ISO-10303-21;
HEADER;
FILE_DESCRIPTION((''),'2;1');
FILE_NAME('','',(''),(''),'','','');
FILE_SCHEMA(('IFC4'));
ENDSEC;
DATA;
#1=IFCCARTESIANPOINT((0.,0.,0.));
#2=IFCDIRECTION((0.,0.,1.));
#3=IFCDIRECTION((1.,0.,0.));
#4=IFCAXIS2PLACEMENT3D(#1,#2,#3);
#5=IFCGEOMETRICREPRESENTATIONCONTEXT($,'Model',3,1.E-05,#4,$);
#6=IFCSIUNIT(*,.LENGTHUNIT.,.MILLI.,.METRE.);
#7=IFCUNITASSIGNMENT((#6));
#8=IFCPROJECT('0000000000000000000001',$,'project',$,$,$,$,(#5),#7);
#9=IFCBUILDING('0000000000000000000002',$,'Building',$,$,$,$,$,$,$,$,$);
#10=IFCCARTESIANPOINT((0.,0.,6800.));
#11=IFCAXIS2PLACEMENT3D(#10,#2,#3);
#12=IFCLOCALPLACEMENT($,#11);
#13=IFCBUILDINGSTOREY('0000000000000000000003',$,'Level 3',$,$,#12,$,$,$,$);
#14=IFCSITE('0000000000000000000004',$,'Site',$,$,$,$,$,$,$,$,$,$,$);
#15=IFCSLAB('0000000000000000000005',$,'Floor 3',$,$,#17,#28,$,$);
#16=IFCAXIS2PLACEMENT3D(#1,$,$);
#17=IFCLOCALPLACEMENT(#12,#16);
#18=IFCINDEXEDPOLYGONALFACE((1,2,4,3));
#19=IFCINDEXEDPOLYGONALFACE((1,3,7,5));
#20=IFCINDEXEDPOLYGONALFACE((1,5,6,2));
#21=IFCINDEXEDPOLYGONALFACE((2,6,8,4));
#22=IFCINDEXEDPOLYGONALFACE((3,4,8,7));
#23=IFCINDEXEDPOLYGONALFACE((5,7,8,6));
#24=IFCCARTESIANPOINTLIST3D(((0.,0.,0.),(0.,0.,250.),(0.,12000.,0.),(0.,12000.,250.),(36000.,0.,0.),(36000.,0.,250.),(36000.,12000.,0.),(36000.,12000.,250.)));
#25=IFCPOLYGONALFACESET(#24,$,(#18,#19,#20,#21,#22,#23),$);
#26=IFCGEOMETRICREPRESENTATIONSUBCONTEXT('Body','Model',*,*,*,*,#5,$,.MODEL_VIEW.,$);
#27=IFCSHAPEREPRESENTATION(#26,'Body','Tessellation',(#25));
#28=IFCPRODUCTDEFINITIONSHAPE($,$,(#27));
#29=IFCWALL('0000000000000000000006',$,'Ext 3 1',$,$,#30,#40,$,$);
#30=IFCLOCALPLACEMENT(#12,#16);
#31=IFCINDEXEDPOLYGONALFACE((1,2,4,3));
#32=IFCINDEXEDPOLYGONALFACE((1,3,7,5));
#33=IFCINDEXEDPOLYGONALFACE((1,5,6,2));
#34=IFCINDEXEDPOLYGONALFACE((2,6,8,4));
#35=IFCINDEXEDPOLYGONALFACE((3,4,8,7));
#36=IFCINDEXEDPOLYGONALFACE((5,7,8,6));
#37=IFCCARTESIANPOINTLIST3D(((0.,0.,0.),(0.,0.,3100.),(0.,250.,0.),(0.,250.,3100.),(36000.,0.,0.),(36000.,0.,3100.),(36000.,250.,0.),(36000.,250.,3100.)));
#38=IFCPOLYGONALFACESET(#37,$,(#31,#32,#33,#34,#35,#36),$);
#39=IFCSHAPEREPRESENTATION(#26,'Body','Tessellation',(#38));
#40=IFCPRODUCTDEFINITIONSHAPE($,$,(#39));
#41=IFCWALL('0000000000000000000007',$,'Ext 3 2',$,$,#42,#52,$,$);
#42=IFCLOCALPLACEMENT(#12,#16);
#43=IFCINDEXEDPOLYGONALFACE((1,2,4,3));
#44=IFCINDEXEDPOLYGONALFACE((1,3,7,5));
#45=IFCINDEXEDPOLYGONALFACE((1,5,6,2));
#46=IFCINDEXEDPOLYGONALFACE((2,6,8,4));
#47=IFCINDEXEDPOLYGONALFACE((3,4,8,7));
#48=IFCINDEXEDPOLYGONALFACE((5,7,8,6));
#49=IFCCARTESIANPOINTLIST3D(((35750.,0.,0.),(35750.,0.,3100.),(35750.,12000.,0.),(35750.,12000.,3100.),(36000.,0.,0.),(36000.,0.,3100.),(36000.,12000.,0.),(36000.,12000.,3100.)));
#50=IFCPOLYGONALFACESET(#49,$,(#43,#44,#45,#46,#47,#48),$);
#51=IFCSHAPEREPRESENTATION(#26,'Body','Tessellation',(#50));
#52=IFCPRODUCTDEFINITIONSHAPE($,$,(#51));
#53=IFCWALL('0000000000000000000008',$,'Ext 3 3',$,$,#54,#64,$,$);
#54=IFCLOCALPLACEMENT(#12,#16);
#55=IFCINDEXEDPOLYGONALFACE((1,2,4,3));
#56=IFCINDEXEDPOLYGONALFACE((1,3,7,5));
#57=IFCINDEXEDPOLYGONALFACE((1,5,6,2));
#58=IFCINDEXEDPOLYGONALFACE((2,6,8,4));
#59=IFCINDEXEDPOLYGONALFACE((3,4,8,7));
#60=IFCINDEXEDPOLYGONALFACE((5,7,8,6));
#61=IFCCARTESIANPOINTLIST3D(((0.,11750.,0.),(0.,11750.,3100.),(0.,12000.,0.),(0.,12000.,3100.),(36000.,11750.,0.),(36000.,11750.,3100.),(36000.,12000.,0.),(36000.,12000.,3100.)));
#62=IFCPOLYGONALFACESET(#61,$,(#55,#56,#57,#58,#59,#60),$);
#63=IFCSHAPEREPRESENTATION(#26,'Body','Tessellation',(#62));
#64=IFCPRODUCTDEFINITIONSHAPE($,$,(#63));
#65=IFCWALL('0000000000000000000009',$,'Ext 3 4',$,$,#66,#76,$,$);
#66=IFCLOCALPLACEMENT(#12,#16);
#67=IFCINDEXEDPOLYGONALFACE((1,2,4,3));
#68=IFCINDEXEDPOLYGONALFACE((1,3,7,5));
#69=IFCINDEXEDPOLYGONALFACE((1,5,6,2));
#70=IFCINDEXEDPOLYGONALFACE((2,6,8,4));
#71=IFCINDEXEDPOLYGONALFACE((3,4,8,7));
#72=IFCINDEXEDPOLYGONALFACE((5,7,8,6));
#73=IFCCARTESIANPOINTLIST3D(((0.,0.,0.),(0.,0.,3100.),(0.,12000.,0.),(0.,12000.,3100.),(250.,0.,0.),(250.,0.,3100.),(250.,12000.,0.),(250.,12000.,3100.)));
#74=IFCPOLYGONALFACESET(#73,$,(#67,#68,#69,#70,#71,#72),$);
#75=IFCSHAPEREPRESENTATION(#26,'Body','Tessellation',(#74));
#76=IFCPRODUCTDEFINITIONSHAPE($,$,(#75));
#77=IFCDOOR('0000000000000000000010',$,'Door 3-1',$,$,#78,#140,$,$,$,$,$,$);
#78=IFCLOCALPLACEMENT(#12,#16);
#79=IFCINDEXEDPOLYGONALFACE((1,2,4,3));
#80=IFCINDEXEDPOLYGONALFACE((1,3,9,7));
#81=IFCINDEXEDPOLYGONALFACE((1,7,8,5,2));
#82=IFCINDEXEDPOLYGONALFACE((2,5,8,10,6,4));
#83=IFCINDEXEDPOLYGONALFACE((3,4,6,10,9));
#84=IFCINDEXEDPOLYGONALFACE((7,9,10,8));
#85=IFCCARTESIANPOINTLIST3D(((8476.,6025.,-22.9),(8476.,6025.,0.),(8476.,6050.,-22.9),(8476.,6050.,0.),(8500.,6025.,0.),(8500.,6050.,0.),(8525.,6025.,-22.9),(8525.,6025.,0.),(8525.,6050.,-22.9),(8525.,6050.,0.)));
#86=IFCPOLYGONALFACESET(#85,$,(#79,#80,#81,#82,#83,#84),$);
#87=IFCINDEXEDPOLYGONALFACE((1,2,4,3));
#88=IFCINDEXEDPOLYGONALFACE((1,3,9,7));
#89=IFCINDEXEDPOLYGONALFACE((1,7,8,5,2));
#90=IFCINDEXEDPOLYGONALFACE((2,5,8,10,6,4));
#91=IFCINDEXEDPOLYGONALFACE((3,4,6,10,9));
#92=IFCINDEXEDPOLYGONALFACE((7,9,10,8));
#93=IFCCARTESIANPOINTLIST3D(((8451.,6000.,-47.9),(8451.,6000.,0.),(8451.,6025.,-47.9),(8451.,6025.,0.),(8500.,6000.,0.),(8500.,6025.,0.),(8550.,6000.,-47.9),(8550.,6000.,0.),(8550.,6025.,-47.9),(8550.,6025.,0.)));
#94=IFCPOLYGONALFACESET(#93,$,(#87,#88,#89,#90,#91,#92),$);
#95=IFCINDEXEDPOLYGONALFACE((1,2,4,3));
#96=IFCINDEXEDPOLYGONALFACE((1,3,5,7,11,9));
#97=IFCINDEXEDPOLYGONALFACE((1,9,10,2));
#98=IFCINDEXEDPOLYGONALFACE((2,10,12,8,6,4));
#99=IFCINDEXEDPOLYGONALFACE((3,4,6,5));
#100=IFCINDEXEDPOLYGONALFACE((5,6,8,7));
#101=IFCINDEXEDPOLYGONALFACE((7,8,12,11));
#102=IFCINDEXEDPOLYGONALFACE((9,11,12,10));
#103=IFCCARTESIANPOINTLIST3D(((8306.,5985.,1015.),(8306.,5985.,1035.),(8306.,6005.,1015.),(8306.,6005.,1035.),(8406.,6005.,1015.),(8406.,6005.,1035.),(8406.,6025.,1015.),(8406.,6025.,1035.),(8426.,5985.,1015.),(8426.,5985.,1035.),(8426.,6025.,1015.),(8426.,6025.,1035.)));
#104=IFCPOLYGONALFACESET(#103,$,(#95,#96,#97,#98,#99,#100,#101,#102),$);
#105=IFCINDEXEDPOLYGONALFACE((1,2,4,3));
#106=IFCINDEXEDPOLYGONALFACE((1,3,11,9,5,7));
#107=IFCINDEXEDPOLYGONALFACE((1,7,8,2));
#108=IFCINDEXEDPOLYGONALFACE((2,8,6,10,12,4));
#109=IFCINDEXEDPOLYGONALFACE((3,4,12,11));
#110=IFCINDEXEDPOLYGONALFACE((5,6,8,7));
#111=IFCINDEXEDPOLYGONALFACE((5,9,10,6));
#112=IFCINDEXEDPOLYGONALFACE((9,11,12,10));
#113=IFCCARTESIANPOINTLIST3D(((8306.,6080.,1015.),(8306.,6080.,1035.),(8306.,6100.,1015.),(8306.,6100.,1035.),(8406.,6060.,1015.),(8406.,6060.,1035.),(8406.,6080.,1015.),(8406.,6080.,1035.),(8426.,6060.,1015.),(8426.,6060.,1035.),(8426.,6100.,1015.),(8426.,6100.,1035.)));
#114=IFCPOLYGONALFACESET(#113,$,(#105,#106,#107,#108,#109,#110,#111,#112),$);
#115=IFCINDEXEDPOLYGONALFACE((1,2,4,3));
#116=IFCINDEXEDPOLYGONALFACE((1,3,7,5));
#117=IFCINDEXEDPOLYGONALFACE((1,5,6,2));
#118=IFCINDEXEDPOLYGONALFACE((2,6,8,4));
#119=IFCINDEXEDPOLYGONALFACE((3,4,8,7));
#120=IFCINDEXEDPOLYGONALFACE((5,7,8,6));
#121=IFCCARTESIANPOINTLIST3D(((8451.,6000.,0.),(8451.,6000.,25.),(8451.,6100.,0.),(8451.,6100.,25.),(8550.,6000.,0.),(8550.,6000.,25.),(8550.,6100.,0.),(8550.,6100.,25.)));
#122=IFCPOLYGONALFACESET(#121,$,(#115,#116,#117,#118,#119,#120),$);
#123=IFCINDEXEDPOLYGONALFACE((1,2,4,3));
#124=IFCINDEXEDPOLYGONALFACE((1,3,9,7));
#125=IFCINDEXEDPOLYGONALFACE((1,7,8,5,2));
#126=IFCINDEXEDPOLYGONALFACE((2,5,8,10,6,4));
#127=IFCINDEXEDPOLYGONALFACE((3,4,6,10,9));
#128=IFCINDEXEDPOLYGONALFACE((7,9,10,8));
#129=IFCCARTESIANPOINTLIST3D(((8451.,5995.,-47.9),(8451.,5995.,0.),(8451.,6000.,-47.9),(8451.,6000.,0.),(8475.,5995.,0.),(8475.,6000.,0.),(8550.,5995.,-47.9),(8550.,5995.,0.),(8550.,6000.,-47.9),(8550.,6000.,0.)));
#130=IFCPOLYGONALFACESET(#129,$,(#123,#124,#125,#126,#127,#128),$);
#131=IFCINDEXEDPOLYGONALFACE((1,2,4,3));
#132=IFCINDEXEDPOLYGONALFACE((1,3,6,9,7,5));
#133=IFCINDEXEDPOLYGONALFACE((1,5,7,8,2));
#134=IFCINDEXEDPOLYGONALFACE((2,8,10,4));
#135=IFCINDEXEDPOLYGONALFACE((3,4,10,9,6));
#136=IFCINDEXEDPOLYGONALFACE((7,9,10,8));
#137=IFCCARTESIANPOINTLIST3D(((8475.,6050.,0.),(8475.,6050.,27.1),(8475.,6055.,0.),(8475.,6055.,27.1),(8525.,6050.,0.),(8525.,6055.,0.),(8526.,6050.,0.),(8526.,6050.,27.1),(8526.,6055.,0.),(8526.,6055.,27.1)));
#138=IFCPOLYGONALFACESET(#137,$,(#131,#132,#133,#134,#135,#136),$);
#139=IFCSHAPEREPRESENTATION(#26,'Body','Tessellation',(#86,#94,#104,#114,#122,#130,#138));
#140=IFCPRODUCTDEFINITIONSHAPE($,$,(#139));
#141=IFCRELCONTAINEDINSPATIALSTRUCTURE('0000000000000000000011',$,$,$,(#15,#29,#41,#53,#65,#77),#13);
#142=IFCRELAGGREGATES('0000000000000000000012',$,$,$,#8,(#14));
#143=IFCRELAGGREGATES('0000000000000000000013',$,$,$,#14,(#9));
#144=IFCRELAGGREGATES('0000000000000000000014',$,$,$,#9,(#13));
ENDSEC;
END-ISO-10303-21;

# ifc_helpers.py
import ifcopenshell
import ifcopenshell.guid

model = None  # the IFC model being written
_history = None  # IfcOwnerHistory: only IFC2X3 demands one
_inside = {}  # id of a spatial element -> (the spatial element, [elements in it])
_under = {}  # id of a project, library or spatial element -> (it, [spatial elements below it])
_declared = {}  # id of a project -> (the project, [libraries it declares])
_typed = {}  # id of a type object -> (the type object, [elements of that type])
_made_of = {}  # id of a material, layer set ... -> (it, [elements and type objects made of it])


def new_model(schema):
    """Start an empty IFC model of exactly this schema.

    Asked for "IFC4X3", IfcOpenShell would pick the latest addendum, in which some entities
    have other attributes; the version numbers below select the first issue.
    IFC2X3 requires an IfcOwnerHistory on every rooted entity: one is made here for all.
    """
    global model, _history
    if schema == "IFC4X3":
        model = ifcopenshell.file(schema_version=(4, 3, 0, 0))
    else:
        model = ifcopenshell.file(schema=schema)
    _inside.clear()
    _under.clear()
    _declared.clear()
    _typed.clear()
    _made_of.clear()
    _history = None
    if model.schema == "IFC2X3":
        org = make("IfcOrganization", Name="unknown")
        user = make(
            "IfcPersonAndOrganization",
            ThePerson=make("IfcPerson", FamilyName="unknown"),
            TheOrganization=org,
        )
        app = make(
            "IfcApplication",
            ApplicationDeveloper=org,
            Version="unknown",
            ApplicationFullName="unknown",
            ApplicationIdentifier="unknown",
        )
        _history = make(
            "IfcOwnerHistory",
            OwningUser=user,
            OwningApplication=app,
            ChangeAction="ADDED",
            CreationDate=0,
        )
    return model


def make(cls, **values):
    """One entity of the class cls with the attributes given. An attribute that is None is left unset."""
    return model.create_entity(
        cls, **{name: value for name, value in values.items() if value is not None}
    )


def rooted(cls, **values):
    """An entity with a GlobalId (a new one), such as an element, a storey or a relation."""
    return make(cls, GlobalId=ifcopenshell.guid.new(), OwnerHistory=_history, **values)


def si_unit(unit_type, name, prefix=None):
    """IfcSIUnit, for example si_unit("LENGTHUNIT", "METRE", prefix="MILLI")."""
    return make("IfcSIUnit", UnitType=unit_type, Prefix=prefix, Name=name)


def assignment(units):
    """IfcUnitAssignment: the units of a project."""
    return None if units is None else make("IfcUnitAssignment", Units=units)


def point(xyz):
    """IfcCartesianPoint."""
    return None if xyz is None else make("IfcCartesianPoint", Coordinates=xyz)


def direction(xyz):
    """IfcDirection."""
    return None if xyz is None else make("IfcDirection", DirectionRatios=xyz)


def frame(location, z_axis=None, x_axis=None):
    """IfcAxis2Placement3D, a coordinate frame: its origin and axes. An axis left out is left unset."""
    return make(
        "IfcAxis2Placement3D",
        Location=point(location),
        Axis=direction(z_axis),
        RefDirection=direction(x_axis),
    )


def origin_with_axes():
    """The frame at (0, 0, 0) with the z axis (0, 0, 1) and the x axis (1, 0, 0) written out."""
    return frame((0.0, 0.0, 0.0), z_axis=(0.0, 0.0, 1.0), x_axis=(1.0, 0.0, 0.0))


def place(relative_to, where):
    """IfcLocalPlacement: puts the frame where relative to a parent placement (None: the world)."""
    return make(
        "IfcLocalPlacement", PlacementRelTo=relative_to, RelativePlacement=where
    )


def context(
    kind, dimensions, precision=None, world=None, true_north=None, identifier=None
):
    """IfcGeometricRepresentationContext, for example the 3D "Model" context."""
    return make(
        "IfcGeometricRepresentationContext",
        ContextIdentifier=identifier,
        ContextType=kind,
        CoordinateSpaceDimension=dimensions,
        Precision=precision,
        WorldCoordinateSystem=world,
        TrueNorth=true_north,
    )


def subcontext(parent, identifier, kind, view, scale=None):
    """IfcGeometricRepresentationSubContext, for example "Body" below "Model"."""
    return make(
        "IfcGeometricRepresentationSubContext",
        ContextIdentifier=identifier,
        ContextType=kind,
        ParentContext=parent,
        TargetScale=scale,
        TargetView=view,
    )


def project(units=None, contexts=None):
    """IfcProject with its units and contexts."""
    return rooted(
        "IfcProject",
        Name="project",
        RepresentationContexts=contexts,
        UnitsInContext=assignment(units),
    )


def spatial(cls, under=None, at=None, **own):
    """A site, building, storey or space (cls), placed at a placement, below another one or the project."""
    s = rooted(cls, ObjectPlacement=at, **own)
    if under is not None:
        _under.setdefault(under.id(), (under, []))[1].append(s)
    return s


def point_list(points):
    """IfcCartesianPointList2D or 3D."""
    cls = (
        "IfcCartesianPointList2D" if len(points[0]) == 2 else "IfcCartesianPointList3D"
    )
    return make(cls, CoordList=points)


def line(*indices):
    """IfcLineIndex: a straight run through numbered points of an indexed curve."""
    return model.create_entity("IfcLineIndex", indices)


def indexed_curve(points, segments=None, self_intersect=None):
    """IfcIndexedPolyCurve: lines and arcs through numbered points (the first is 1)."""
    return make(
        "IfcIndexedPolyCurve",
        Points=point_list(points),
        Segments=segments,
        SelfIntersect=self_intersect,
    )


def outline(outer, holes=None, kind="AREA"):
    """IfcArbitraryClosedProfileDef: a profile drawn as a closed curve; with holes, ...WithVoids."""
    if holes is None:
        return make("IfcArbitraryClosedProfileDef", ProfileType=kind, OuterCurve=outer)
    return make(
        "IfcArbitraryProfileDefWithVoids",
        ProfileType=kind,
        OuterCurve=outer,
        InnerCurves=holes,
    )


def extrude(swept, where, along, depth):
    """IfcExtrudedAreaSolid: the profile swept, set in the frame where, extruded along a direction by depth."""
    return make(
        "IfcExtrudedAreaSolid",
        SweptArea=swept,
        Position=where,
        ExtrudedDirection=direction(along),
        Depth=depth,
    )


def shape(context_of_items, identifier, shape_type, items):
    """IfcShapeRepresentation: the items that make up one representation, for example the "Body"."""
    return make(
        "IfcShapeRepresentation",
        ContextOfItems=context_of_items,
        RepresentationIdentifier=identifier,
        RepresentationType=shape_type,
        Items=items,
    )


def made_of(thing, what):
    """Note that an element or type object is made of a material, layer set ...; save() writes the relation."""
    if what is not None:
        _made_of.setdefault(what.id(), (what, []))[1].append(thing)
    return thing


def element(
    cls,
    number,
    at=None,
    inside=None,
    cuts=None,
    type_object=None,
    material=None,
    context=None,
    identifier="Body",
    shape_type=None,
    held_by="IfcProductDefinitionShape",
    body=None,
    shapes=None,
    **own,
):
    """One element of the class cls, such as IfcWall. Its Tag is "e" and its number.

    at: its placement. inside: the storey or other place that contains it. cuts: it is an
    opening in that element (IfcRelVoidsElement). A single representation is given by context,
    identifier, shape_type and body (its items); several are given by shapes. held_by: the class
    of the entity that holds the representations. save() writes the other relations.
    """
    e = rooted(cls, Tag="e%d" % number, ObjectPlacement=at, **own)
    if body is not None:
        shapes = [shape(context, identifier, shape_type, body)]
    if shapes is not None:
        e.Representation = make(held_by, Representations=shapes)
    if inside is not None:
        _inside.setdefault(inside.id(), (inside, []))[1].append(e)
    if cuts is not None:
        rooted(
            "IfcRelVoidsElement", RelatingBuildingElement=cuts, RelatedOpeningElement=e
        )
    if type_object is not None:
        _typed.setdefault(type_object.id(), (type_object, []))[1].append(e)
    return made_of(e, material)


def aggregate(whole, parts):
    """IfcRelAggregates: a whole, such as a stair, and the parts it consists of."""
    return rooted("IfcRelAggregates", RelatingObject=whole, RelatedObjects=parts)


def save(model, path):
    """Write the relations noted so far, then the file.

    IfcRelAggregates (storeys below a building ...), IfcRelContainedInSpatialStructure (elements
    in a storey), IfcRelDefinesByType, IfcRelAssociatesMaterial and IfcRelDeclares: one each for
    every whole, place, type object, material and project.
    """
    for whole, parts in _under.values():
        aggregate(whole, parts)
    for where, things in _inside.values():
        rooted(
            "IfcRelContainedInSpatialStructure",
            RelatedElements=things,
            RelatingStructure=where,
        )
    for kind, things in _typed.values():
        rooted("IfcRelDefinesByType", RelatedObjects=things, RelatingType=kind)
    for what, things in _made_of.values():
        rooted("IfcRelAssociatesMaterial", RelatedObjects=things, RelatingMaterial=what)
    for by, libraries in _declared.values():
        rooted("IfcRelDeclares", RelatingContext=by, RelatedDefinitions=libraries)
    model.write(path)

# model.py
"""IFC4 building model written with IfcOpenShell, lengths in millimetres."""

from ifc_helpers import new_model, si_unit, frame, origin_with_axes, place, context, subcontext, project, spatial, line, indexed_curve, outline, extrude, element, save


model = new_model("IFC4")

# Units and contexts
model_context = context("Model", 3, precision=1e-05, world=origin_with_axes())
body_context = subcontext(model_context, "Body", "Model", "MODEL_VIEW")
ifc_project = project(units=[si_unit("LENGTHUNIT", "METRE", prefix="MILLI")], contexts=[model_context])

# Site, building, storey
site = spatial("IfcSite", under=ifc_project, Name="Site")
building = spatial("IfcBuilding", under=site, Name="Building")
storey_placement = place(None, frame((0.0, 0.0, 6800.0), z_axis=(0.0, 0.0, 1.0), x_axis=(1.0, 0.0, 0.0)))
storey = spatial("IfcBuildingStorey", under=building, at=storey_placement, Name="Level 3")

# Slab
slab_placement = place(storey_placement, origin_with_axes())
element("IfcSlab", 1, at=slab_placement, inside=storey, Name="Floor 3", context=body_context, shape_type="SweptSolid", body=[
    extrude(outline(indexed_curve([(0.0, 0.0), (36000.0, 0.0), (36000.0, 12000.0), (0.0, 12000.0), (0.0, 0.0)])), None, (0.0, 0.0, 1.0), 250.0),
])

# Walls
wall_1_placement = place(storey_placement, origin_with_axes())
element("IfcWall", 2, at=wall_1_placement, inside=storey, Name="Ext 3 1", context=body_context, shape_type="SweptSolid", body=[
    extrude(outline(indexed_curve([(0.0, 0.0), (0.0, 250.0), (36000.0, 250.0), (36000.0, 0.0), (0.0, 0.0)], self_intersect=False)), origin_with_axes(), (0.0, 0.0, 1.0), 3100.0),
])
wall_2_placement = place(storey_placement, frame((36000.0, 0.0, 0.0), z_axis=(0.0, 0.0, 1.0), x_axis=(0.0, 1.0, 0.0)))
element("IfcWall", 3, at=wall_2_placement, inside=storey, Name="Ext 3 2", context=body_context, shape_type="SweptSolid", body=[
    extrude(outline(indexed_curve([(0.0, 0.0), (0.0, 250.0), (12000.0, 250.0), (12000.0, 0.0), (0.0, 0.0)], self_intersect=False)), origin_with_axes(), (0.0, 0.0, 1.0), 3100.0),
])
wall_3_placement = place(storey_placement, frame((36000.0, 12000.0, 0.0), z_axis=(0.0, 0.0, 1.0), x_axis=(-1.0, 0.0, 0.0)))
element("IfcWall", 4, at=wall_3_placement, inside=storey, Name="Ext 3 3", context=body_context, shape_type="SweptSolid", body=[
    extrude(outline(indexed_curve([(0.0, 0.0), (0.0, 250.0), (36000.0, 250.0), (36000.0, 0.0), (0.0, 0.0)], self_intersect=False)), origin_with_axes(), (0.0, 0.0, 1.0), 3100.0),
])
wall_4_placement = place(storey_placement, frame((0.0, 12000.0, 0.0), z_axis=(0.0, 0.0, 1.0), x_axis=(0.0, -1.0, 0.0)))
element("IfcWall", 5, at=wall_4_placement, inside=storey, Name="Ext 3 4", context=body_context, shape_type="SweptSolid", body=[
    extrude(outline(indexed_curve([(0.0, 0.0), (0.0, 250.0), (12000.0, 250.0), (12000.0, 0.0), (0.0, 0.0)], self_intersect=False)), origin_with_axes(), (0.0, 0.0, 1.0), 3100.0),
])

# Door
door_1_placement = place(storey_placement, frame((8500.0, 6000.0, 0.0), z_axis=(0.0, 0.0, 1.0), x_axis=(1.0, 0.0, 0.0)))
element("IfcDoor", 6, at=door_1_placement, inside=storey, Name="Door 3-1", context=body_context, shape_type="SweptSolid", body=[
    extrude(outline(indexed_curve([(0.0, 0.0), (0.0, 2.1), (1.0, 2.1), (1.0, 0.0), (-24.0, 0.0), (-24.0, -22.9), (25.0, -22.9), (25.0, 0.0)], segments=[line(1, 2, 3, 4, 5, 6, 7, 8, 1)])), frame((0.0, 25.0, 0.0), z_axis=(0.0, -1.0, 0.0), x_axis=(1.0, 0.0, 0.0)), (0.0, 0.0, -1.0), 25.0),
    extrude(outline(indexed_curve([(0.0, 0.0), (0.0, 2.1), (1.0, 2.1), (1.0, 0.0), (-49.0, 0.0), (-49.0, -47.9), (50.0, -47.9), (50.0, 0.0)], segments=[line(1, 2, 3, 4, 5, 6, 7, 8, 1)])), frame((0.0, 0.0, 0.0), z_axis=(0.0, -1.0, 0.0), x_axis=(1.0, 0.0, 0.0)), (0.0, 0.0, -1.0), 25.0),
    extrude(outline(indexed_curve([(0.0, 0.0), (-49.0, 0.0), (-49.0, 35.0), (0.0, 35.0)], segments=[line(1, 2, 3, 4, 1)])), frame((25.0, 25.0, 25.0), z_axis=(0.0, 0.0, 1.0), x_axis=(1.0, 0.0, 0.0)), (0.0, 0.0, 1.0), -47.9),
    extrude(outline(indexed_curve([(0.0, 0.0), (0.0, -40.0), (-120.0, -40.0), (-120.0, -20.0), (-20.0, -20.0), (-20.0, 0.0)], segments=[line(1, 2, 3, 4, 5, 6, 1)])), frame((-74.0, 25.0, 1015.0), z_axis=(0.0, 0.0, 1.0), x_axis=(1.0, 0.0, 0.0)), (0.0, 0.0, 1.0), 20.0),
    extrude(outline(indexed_curve([(0.0, 0.0), (0.0, 40.0), (-120.0, 40.0), (-120.0, 20.0), (-20.0, 20.0), (-20.0, 0.0)], segments=[line(1, 2, 3, 4, 5, 6, 1)])), frame((-74.0, 60.0, 1015.0), z_axis=(0.0, 0.0, 1.0), x_axis=(1.0, 0.0, 0.0)), (0.0, 0.0, 1.0), 20.0),
    extrude(outline(indexed_curve([(0.0, 0.0), (-99.0, 0.0), (-99.0, 100.0), (0.0, 100.0)], segments=[line(1, 2, 3, 4, 1)])), frame((50.0, 0.0, 0.0), z_axis=(0.0, 0.0, 1.0), x_axis=(1.0, 0.0, 0.0)), (0.0, 0.0, 1.0), 25.0),
    extrude(outline(indexed_curve([(0.0, 0.0), (0.0, 27.1), (51.0, 27.1), (51.0, 0.0), (-24.0, 0.0), (-24.0, -47.9), (75.0, -47.9), (75.0, 0.0)], segments=[line(1, 2, 3, 4, 5, 6, 7, 8, 1)])), frame((-25.0, -5.0, 0.0), z_axis=(0.0, -1.0, 0.0), x_axis=(1.0, 0.0, 0.0)), (0.0, 0.0, -1.0), 5.0),
    extrude(outline(indexed_curve([(0.0, 0.0), (0.0, 27.1), (51.0, 27.1), (51.0, 0.0), (1.0, 0.0), (1.0, -22.9), (50.0, -22.9), (50.0, 0.0)], segments=[line(1, 2, 3, 4, 5, 6, 7, 8, 1)])), frame((-25.0, 50.0, 0.0), z_axis=(0.0, -1.0, 0.0), x_axis=(1.0, 0.0, 0.0)), (0.0, 0.0, -1.0), 5.0),
])

save(model, "model.ifc")
